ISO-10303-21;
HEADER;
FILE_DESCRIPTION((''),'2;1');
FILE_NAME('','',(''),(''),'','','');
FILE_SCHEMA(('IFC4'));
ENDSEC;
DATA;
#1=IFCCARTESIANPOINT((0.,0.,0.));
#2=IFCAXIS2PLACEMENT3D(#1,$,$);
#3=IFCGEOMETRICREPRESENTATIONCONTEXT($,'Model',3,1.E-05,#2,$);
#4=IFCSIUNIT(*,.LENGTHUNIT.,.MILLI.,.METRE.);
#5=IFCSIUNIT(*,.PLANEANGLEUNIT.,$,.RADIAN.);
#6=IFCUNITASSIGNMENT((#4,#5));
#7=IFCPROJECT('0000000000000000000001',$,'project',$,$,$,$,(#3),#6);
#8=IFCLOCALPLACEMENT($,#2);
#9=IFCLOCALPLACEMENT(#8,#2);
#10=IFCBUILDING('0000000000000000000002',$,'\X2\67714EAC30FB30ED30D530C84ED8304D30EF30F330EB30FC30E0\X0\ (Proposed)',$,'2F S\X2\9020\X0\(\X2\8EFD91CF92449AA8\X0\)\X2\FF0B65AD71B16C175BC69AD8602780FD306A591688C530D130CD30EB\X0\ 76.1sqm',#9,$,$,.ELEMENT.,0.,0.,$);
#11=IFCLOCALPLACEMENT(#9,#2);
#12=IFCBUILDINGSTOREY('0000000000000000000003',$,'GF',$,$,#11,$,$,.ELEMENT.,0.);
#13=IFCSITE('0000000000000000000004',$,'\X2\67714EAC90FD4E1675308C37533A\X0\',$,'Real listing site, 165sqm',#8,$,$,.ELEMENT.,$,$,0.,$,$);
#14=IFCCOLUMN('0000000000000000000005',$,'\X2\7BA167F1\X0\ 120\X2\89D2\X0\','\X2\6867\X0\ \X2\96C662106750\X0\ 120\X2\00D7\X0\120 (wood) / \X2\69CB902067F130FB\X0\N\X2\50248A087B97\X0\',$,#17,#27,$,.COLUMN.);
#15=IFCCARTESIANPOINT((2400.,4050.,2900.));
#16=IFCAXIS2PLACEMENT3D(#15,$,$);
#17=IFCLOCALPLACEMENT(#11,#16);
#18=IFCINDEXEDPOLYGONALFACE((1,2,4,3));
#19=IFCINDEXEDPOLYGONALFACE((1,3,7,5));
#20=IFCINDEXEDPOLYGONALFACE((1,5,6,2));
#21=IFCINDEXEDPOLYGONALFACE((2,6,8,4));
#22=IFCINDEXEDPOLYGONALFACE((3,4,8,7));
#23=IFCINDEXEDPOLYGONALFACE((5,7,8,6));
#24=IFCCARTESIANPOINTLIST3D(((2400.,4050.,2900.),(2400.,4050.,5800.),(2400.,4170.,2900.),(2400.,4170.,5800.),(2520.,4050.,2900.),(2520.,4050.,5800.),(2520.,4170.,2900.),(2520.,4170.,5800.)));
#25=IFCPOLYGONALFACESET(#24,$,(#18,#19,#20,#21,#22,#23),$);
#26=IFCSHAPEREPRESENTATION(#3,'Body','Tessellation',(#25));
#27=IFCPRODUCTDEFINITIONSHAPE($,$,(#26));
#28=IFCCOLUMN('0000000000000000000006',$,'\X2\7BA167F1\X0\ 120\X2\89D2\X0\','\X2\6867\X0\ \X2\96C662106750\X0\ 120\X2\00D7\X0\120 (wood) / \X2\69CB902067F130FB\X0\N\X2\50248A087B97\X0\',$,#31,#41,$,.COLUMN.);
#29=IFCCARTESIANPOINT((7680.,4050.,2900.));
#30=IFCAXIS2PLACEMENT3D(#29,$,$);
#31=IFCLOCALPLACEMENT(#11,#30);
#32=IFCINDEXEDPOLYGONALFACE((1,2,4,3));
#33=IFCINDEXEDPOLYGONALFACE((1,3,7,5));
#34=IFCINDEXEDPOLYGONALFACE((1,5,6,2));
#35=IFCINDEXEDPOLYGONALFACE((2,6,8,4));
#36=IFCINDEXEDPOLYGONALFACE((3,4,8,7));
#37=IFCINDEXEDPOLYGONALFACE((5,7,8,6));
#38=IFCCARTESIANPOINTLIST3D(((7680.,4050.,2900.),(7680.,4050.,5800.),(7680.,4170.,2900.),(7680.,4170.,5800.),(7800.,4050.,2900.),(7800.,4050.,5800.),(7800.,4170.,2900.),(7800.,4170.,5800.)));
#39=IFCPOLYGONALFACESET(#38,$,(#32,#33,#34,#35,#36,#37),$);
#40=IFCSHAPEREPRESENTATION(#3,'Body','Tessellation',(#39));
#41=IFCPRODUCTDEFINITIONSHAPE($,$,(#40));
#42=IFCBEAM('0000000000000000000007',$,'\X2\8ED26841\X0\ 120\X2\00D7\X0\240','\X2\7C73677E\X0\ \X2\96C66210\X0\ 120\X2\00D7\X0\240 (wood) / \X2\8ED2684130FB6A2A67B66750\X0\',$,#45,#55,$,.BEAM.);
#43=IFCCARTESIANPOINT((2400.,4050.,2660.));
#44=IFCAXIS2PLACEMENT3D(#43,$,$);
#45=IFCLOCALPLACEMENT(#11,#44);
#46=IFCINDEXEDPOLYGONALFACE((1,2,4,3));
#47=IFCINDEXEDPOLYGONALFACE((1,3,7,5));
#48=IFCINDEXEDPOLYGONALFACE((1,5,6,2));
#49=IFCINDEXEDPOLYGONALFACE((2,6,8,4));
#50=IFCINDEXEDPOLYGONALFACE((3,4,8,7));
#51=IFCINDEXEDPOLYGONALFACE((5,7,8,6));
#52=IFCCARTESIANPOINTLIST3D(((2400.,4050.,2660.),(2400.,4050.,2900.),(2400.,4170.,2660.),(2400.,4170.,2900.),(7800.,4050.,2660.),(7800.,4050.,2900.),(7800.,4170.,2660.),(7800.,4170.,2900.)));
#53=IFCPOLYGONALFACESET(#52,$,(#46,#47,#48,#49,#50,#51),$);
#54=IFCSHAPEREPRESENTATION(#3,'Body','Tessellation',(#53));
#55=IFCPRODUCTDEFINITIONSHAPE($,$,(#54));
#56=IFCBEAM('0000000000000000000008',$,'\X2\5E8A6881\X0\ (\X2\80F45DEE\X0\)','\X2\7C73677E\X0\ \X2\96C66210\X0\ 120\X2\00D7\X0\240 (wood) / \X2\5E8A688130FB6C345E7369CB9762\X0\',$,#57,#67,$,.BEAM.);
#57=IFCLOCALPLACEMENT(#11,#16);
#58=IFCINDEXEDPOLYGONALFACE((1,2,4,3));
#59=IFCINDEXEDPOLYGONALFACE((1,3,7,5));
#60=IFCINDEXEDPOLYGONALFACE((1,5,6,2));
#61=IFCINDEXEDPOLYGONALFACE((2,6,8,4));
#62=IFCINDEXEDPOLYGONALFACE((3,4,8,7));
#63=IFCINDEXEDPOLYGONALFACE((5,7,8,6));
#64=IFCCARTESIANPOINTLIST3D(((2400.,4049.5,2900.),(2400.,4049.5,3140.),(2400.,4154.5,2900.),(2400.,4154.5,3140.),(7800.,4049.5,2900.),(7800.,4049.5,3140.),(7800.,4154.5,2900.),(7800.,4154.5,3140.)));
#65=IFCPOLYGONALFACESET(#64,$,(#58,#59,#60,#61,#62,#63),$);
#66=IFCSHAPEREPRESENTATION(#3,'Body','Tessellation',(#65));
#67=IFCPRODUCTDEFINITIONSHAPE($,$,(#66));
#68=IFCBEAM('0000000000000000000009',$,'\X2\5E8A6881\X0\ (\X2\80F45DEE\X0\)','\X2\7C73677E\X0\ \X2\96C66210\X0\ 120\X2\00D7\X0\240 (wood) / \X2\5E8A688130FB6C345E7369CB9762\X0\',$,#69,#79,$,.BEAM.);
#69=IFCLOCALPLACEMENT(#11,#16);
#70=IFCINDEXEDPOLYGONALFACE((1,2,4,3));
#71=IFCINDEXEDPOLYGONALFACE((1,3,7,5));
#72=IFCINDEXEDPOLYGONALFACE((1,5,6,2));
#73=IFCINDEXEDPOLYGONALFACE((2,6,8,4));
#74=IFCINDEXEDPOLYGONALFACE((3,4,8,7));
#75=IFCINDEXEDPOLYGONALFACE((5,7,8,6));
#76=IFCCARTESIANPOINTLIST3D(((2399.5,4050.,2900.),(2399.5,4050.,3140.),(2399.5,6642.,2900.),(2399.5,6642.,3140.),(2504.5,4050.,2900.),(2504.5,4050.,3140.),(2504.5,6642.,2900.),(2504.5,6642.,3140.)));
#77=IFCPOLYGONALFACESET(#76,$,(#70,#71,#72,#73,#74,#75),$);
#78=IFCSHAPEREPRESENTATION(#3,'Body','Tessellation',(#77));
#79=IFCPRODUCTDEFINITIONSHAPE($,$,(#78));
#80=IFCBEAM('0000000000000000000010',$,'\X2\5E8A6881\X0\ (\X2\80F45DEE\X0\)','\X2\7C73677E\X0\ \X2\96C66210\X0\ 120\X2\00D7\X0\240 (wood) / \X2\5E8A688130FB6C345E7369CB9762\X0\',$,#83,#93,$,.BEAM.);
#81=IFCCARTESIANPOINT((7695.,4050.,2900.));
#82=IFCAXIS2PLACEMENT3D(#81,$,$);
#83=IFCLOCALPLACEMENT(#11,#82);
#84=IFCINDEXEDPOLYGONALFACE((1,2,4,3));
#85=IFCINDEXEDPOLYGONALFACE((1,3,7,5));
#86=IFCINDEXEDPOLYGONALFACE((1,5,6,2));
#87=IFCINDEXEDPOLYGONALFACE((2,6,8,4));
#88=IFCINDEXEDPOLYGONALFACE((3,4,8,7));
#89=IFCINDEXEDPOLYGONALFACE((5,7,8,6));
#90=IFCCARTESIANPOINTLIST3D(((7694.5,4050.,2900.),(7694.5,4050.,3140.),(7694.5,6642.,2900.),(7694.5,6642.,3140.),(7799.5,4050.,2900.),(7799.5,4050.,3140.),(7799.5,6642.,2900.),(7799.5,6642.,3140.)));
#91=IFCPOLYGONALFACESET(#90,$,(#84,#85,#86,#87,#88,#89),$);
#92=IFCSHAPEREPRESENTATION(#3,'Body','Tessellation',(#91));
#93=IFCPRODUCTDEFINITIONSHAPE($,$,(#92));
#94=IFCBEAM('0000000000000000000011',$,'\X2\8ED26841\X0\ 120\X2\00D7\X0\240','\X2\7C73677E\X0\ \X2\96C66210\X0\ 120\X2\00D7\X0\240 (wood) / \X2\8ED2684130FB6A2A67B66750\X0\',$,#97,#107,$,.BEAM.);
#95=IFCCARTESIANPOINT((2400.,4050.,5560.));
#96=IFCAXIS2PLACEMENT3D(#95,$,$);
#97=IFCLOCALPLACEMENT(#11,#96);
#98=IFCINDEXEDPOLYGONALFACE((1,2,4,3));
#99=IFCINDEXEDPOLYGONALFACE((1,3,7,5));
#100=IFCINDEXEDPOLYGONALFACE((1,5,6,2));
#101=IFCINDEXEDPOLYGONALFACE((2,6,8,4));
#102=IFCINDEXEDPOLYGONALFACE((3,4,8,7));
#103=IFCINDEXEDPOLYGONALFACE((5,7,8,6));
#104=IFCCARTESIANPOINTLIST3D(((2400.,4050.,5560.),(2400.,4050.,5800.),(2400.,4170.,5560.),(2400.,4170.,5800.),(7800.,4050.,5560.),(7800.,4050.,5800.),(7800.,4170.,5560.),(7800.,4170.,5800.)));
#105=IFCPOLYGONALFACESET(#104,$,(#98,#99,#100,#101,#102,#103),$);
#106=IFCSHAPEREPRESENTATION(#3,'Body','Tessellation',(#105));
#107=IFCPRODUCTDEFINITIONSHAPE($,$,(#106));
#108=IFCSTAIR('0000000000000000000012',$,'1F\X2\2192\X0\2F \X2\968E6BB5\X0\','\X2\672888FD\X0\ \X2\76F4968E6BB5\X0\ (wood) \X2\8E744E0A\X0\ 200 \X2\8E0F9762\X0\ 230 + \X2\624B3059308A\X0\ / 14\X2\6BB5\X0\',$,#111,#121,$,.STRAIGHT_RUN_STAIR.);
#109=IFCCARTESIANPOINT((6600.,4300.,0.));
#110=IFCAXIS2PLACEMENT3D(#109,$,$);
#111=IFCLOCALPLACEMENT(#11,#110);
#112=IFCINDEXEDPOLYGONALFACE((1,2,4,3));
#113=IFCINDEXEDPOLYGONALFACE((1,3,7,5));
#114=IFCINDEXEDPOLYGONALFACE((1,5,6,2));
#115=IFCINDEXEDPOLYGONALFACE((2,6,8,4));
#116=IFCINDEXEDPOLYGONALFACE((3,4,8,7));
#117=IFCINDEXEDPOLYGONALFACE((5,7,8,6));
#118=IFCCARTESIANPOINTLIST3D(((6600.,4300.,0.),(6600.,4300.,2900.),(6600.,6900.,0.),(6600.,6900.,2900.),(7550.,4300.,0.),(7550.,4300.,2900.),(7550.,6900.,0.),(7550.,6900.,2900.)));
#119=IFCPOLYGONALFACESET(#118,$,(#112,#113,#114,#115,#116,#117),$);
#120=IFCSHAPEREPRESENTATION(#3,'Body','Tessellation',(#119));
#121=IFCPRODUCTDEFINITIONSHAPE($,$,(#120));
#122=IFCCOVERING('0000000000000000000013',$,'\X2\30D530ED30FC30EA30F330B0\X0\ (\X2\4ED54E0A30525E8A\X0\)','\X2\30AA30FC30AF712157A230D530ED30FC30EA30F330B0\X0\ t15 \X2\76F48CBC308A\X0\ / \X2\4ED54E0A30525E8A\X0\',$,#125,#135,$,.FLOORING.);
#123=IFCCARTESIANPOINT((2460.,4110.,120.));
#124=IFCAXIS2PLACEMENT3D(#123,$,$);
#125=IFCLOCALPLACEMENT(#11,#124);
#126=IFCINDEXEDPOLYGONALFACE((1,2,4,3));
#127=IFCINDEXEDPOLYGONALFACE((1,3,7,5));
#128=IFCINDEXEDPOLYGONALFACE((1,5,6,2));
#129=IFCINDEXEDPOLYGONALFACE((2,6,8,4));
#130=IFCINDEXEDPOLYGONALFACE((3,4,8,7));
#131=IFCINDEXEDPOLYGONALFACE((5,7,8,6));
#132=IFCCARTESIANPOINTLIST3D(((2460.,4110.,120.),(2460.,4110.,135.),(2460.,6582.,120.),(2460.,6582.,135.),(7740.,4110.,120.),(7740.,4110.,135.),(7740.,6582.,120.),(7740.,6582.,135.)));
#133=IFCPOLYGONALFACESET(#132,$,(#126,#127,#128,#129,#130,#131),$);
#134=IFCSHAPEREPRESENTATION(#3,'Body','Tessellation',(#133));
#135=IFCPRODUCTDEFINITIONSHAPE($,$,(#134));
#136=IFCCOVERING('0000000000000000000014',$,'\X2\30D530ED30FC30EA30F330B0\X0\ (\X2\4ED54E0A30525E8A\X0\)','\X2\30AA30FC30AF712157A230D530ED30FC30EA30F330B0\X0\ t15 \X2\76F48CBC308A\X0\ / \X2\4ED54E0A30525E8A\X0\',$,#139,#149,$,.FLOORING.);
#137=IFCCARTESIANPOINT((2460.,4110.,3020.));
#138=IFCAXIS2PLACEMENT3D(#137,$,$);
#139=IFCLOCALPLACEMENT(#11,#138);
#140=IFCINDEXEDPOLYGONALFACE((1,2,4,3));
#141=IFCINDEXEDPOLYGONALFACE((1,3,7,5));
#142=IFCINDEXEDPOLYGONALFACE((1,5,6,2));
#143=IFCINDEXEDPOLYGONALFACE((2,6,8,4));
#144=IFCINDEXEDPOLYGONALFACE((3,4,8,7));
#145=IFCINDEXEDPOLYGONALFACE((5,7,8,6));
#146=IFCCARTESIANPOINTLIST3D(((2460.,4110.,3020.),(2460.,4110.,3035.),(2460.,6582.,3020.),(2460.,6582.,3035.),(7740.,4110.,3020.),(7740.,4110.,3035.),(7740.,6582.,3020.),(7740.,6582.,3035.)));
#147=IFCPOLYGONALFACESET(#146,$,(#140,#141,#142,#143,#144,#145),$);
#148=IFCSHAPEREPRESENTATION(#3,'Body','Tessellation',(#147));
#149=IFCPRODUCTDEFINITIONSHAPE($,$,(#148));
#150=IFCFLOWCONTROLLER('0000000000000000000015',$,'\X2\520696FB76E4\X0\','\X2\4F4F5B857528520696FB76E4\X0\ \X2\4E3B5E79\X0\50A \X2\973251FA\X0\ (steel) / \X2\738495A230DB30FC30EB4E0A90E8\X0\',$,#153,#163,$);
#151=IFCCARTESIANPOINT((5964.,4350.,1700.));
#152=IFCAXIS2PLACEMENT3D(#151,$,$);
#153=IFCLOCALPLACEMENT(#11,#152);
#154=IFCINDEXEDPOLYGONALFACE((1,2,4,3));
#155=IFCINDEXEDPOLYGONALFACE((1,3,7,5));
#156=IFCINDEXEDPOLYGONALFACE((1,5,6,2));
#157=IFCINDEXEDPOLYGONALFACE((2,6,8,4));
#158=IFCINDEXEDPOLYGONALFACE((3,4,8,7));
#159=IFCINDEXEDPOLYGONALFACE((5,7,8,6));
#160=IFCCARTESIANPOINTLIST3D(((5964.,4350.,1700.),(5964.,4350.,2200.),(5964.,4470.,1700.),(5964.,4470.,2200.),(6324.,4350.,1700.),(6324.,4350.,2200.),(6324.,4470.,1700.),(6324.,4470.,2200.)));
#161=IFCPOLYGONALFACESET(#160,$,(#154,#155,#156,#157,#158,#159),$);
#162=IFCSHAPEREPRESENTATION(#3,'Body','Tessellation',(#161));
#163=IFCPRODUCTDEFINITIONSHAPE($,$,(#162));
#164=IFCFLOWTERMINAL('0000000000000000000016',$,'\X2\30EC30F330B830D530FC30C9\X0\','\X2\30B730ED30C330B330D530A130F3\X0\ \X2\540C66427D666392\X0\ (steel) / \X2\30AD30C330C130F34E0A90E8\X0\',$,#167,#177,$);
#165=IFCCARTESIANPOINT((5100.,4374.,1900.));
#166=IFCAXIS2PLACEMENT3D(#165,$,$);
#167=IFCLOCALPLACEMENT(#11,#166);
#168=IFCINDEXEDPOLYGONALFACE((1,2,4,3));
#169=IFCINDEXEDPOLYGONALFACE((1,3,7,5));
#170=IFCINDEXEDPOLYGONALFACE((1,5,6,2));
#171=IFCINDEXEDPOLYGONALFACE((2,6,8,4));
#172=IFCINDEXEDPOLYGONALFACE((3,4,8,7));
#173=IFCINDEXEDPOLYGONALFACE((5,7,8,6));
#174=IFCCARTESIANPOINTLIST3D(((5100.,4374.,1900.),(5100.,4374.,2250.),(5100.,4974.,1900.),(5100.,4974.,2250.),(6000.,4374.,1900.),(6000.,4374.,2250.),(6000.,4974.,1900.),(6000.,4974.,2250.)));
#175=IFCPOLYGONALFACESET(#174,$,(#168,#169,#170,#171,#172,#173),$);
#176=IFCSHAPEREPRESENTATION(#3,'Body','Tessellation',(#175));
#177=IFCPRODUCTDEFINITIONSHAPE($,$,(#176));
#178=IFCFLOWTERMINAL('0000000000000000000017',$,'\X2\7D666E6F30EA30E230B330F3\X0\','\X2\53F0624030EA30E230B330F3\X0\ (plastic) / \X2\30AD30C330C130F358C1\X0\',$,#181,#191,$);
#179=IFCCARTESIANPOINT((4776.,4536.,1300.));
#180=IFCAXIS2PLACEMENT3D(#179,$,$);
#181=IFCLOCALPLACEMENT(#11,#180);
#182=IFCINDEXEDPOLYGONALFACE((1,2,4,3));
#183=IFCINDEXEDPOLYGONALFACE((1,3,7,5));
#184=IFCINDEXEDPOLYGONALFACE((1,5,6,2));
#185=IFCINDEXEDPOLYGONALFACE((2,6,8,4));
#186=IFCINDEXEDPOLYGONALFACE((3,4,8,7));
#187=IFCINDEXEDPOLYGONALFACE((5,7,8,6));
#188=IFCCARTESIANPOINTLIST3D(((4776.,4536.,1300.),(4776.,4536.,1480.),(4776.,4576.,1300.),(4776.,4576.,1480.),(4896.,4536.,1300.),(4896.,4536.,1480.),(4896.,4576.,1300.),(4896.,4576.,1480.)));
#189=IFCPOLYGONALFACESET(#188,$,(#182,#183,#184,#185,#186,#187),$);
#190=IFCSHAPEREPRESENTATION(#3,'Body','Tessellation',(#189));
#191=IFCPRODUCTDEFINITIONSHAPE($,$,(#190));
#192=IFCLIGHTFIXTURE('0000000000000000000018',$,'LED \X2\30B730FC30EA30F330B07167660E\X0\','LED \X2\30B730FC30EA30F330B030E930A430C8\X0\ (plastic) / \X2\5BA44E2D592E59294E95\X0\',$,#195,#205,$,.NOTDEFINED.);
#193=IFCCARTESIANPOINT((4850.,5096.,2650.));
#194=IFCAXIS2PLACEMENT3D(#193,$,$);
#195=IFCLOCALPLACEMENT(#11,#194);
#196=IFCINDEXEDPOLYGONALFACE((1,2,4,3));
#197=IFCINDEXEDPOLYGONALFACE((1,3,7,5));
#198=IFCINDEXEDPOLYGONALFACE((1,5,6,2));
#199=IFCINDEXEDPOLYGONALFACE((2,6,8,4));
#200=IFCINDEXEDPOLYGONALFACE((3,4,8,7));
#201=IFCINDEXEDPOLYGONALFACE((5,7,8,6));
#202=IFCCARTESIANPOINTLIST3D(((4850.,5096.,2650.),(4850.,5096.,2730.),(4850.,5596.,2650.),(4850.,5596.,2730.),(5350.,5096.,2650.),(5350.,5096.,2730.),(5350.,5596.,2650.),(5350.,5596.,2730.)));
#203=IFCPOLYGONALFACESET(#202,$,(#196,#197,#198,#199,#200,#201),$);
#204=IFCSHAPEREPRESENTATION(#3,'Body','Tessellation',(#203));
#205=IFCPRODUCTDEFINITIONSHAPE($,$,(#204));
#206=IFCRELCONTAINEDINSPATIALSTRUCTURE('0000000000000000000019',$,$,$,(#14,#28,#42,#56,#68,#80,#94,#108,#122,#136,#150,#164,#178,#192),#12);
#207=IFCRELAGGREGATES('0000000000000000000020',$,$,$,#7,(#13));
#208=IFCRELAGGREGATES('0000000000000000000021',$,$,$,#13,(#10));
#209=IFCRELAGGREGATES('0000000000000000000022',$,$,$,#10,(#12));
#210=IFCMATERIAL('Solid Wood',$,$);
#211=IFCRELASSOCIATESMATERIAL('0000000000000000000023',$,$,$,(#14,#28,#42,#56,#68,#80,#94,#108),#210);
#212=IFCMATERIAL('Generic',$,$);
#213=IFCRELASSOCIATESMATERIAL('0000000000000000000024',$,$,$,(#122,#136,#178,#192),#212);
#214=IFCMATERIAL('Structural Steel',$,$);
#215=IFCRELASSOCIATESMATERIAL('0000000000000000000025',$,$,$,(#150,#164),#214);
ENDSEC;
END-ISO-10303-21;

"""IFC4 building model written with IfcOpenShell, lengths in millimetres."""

from ifc_helpers import new_model, si_unit, frame, frame_2d, origin, place, context, project, spatial, rectangle, extrude, material, element, save


model = new_model("IFC4")

# Units and contexts
model_context = context("Model", 3, precision=1e-05, world=origin())
ifc_project = project(units=[si_unit("LENGTHUNIT", "METRE", prefix="MILLI"), si_unit("PLANEANGLEUNIT", "RADIAN")], contexts=[model_context])

# Site, building, storey
site_placement = place(None, origin())
site = spatial("IfcSite", under=ifc_project, at=site_placement, Name="東京都世田谷区", ObjectType="Real listing site, 165sqm", CompositionType="ELEMENT", RefElevation=0.0)
building_placement = place(site_placement, origin())
building = spatial("IfcBuilding", under=site, at=building_placement, Name="東京・ロフト付きワンルーム (Proposed)", ObjectType="2F S造(軽量鉄骨)＋断熱気密高性能な外装パネル 76.1sqm", CompositionType="ELEMENT", ElevationOfRefHeight=0.0, ElevationOfTerrain=0.0)
storey_placement = place(building_placement, origin())
storey = spatial("IfcBuildingStorey", under=building, at=storey_placement, Name="GF", CompositionType="ELEMENT", Elevation=0.0)

# Columns
ifc_material_1 = material(Name="Solid Wood")
column_1_placement = place(storey_placement, frame((2400.0, 4050.0, 2900.0)))
element("IfcColumn", 1, at=column_1_placement, inside=storey, material=ifc_material_1, Name="管柱 120角", Description="桧 集成材 120×120 (wood) / 構造柱・N値計算", PredefinedType="COLUMN", context=model_context, shape_type="SweptSolid", body=[
    extrude(rectangle(XDim=120.0, YDim=120.0, at=frame_2d((60.0, 60.0))), frame((2400.0, 4050.0, 2900.0)), (0.0, 0.0, 1.0), 2900.0),
])
column_2_placement = place(storey_placement, frame((7680.0, 4050.0, 2900.0)))
element("IfcColumn", 2, at=column_2_placement, inside=storey, material=ifc_material_1, Name="管柱 120角", Description="桧 集成材 120×120 (wood) / 構造柱・N値計算", PredefinedType="COLUMN", context=model_context, shape_type="SweptSolid", body=[
    extrude(rectangle(XDim=120.0, YDim=120.0, at=frame_2d((60.0, 60.0))), frame((7680.0, 4050.0, 2900.0)), (0.0, 0.0, 1.0), 2900.0),
])

# Beams
beam_1_placement = place(storey_placement, frame((2400.0, 4050.0, 2660.0)))
element("IfcBeam", 3, at=beam_1_placement, inside=storey, material=ifc_material_1, Name="軒桁 120×240", Description="米松 集成 120×240 (wood) / 軒桁・横架材", PredefinedType="BEAM", context=model_context, shape_type="SweptSolid", body=[
    extrude(rectangle(XDim=5400.0, YDim=120.0, at=frame_2d((2700.0, 60.0))), frame((2400.0, 4050.0, 2660.0)), (0.0, 0.0, 1.0), 240.0),
])
beam_2_placement = place(storey_placement, frame((2400.0, 4050.0, 2900.0)))
element("IfcBeam", 4, at=beam_2_placement, inside=storey, material=ifc_material_1, Name="床梁 (胴差)", Description="米松 集成 120×240 (wood) / 床梁・水平構面", PredefinedType="BEAM", context=model_context, shape_type="SweptSolid", body=[
    extrude(rectangle(XDim=5400.0, YDim=105.0, at=frame_2d((2700.0, 52.0))), frame((2400.0, 4050.0, 2900.0)), (0.0, 0.0, 1.0), 240.0),
])
beam_3_placement = place(storey_placement, frame((2400.0, 4050.0, 2900.0)))
element("IfcBeam", 5, at=beam_3_placement, inside=storey, material=ifc_material_1, Name="床梁 (胴差)", Description="米松 集成 120×240 (wood) / 床梁・水平構面", PredefinedType="BEAM", context=model_context, shape_type="SweptSolid", body=[
    extrude(rectangle(XDim=105.0, YDim=2592.0, at=frame_2d((52.0, 1296.0))), frame((2400.0, 4050.0, 2900.0)), (0.0, 0.0, 1.0), 240.0),
])
beam_4_placement = place(storey_placement, frame((7695.0, 4050.0, 2900.0)))
element("IfcBeam", 6, at=beam_4_placement, inside=storey, material=ifc_material_1, Name="床梁 (胴差)", Description="米松 集成 120×240 (wood) / 床梁・水平構面", PredefinedType="BEAM", context=model_context, shape_type="SweptSolid", body=[
    extrude(rectangle(XDim=105.0, YDim=2592.0, at=frame_2d((52.0, 1296.0))), frame((7695.0, 4050.0, 2900.0)), (0.0, 0.0, 1.0), 240.0),
])
beam_5_placement = place(storey_placement, frame((2400.0, 4050.0, 5560.0)))
element("IfcBeam", 7, at=beam_5_placement, inside=storey, material=ifc_material_1, Name="軒桁 120×240", Description="米松 集成 120×240 (wood) / 軒桁・横架材", PredefinedType="BEAM", context=model_context, shape_type="SweptSolid", body=[
    extrude(rectangle(XDim=5400.0, YDim=120.0, at=frame_2d((2700.0, 60.0))), frame((2400.0, 4050.0, 5560.0)), (0.0, 0.0, 1.0), 240.0),
])

# Stair
stair_placement = place(storey_placement, frame((6600.0, 4300.0, 0.0)))
element("IfcStair", 8, at=stair_placement, inside=storey, material=ifc_material_1, Name="1F→2F 階段", Description="木製 直階段 (wood) 蹴上 200 踏面 230 + 手すり / 14段", PredefinedType="STRAIGHT_RUN_STAIR", context=model_context, shape_type="SweptSolid", body=[
    extrude(rectangle(XDim=950.0, YDim=2600.0, at=frame_2d((475.0, 1300.0))), frame((6600.0, 4300.0, 0.0)), (0.0, 0.0, 1.0), 2900.0),
])

# Coverings
ifc_material_2 = material(Name="Generic")
covering_1_placement = place(storey_placement, frame((2460.0, 4110.0, 120.0)))
element("IfcCovering", 9, at=covering_1_placement, inside=storey, material=ifc_material_2, Name="フローリング (仕上げ床)", Description="オーク無垢フローリング t15 直貼り / 仕上げ床", PredefinedType="FLOORING", context=model_context, shape_type="SweptSolid", body=[
    extrude(rectangle(XDim=5280.0, YDim=2472.0, at=frame_2d((2640.0, 1236.0))), frame((2460.0, 4110.0, 120.0)), (0.0, 0.0, 1.0), 15.0),
])
covering_2_placement = place(storey_placement, frame((2460.0, 4110.0, 3020.0)))
element("IfcCovering", 10, at=covering_2_placement, inside=storey, material=ifc_material_2, Name="フローリング (仕上げ床)", Description="オーク無垢フローリング t15 直貼り / 仕上げ床", PredefinedType="FLOORING", context=model_context, shape_type="SweptSolid", body=[
    extrude(rectangle(XDim=5280.0, YDim=2472.0, at=frame_2d((2640.0, 1236.0))), frame((2460.0, 4110.0, 3020.0)), (0.0, 0.0, 1.0), 15.0),
])

# Flow controller
ifc_material_3 = material(Name="Structural Steel")
flow_controller_placement = place(storey_placement, frame((5964.0, 4350.0, 1700.0)))
element("IfcFlowController", 11, at=flow_controller_placement, inside=storey, material=ifc_material_3, Name="分電盤", Description="住宅用分電盤 主幹50A 露出 (steel) / 玄関ホール上部", context=model_context, shape_type="SweptSolid", body=[
    extrude(rectangle(XDim=360.0, YDim=120.0, at=frame_2d((180.0, 60.0))), frame((5964.0, 4350.0, 1700.0)), (0.0, 0.0, 1.0), 500.0),
])

# Flow terminals
flow_terminal_1_placement = place(storey_placement, frame((5100.0, 4374.0, 1900.0)))
element("IfcFlowTerminal", 12, at=flow_terminal_1_placement, inside=storey, material=ifc_material_3, Name="レンジフード", Description="シロッコファン 同時給排 (steel) / キッチン上部", context=model_context, shape_type="SweptSolid", body=[
    extrude(rectangle(XDim=900.0, YDim=600.0, at=frame_2d((450.0, 300.0))), frame((5100.0, 4374.0, 1900.0)), (0.0, 0.0, 1.0), 350.0),
])
flow_terminal_2_placement = place(storey_placement, frame((4776.0, 4536.0, 1300.0)))
element("IfcFlowTerminal", 13, at=flow_terminal_2_placement, inside=storey, material=ifc_material_2, Name="給湯リモコン", Description="台所リモコン (plastic) / キッチン壁", context=model_context, shape_type="SweptSolid", body=[
    extrude(rectangle(XDim=120.0, YDim=40.0, at=frame_2d((60.0, 20.0))), frame((4776.0, 4536.0, 1300.0)), (0.0, 0.0, 1.0), 180.0),
])

# Light fixture
light_fixture_1_placement = place(storey_placement, frame((4850.0, 5096.0, 2650.0)))
element("IfcLightFixture", 14, at=light_fixture_1_placement, inside=storey, material=ifc_material_2, Name="LED シーリング照明", Description="LED シーリングライト (plastic) / 室中央天井", PredefinedType="NOTDEFINED", context=model_context, shape_type="SweptSolid", body=[
    extrude(rectangle(XDim=500.0, YDim=500.0, at=frame_2d((250.0, 250.0))), frame((4850.0, 5096.0, 2650.0)), (0.0, 0.0, 1.0), 80.0),
])

save(model, "model.ifc")
